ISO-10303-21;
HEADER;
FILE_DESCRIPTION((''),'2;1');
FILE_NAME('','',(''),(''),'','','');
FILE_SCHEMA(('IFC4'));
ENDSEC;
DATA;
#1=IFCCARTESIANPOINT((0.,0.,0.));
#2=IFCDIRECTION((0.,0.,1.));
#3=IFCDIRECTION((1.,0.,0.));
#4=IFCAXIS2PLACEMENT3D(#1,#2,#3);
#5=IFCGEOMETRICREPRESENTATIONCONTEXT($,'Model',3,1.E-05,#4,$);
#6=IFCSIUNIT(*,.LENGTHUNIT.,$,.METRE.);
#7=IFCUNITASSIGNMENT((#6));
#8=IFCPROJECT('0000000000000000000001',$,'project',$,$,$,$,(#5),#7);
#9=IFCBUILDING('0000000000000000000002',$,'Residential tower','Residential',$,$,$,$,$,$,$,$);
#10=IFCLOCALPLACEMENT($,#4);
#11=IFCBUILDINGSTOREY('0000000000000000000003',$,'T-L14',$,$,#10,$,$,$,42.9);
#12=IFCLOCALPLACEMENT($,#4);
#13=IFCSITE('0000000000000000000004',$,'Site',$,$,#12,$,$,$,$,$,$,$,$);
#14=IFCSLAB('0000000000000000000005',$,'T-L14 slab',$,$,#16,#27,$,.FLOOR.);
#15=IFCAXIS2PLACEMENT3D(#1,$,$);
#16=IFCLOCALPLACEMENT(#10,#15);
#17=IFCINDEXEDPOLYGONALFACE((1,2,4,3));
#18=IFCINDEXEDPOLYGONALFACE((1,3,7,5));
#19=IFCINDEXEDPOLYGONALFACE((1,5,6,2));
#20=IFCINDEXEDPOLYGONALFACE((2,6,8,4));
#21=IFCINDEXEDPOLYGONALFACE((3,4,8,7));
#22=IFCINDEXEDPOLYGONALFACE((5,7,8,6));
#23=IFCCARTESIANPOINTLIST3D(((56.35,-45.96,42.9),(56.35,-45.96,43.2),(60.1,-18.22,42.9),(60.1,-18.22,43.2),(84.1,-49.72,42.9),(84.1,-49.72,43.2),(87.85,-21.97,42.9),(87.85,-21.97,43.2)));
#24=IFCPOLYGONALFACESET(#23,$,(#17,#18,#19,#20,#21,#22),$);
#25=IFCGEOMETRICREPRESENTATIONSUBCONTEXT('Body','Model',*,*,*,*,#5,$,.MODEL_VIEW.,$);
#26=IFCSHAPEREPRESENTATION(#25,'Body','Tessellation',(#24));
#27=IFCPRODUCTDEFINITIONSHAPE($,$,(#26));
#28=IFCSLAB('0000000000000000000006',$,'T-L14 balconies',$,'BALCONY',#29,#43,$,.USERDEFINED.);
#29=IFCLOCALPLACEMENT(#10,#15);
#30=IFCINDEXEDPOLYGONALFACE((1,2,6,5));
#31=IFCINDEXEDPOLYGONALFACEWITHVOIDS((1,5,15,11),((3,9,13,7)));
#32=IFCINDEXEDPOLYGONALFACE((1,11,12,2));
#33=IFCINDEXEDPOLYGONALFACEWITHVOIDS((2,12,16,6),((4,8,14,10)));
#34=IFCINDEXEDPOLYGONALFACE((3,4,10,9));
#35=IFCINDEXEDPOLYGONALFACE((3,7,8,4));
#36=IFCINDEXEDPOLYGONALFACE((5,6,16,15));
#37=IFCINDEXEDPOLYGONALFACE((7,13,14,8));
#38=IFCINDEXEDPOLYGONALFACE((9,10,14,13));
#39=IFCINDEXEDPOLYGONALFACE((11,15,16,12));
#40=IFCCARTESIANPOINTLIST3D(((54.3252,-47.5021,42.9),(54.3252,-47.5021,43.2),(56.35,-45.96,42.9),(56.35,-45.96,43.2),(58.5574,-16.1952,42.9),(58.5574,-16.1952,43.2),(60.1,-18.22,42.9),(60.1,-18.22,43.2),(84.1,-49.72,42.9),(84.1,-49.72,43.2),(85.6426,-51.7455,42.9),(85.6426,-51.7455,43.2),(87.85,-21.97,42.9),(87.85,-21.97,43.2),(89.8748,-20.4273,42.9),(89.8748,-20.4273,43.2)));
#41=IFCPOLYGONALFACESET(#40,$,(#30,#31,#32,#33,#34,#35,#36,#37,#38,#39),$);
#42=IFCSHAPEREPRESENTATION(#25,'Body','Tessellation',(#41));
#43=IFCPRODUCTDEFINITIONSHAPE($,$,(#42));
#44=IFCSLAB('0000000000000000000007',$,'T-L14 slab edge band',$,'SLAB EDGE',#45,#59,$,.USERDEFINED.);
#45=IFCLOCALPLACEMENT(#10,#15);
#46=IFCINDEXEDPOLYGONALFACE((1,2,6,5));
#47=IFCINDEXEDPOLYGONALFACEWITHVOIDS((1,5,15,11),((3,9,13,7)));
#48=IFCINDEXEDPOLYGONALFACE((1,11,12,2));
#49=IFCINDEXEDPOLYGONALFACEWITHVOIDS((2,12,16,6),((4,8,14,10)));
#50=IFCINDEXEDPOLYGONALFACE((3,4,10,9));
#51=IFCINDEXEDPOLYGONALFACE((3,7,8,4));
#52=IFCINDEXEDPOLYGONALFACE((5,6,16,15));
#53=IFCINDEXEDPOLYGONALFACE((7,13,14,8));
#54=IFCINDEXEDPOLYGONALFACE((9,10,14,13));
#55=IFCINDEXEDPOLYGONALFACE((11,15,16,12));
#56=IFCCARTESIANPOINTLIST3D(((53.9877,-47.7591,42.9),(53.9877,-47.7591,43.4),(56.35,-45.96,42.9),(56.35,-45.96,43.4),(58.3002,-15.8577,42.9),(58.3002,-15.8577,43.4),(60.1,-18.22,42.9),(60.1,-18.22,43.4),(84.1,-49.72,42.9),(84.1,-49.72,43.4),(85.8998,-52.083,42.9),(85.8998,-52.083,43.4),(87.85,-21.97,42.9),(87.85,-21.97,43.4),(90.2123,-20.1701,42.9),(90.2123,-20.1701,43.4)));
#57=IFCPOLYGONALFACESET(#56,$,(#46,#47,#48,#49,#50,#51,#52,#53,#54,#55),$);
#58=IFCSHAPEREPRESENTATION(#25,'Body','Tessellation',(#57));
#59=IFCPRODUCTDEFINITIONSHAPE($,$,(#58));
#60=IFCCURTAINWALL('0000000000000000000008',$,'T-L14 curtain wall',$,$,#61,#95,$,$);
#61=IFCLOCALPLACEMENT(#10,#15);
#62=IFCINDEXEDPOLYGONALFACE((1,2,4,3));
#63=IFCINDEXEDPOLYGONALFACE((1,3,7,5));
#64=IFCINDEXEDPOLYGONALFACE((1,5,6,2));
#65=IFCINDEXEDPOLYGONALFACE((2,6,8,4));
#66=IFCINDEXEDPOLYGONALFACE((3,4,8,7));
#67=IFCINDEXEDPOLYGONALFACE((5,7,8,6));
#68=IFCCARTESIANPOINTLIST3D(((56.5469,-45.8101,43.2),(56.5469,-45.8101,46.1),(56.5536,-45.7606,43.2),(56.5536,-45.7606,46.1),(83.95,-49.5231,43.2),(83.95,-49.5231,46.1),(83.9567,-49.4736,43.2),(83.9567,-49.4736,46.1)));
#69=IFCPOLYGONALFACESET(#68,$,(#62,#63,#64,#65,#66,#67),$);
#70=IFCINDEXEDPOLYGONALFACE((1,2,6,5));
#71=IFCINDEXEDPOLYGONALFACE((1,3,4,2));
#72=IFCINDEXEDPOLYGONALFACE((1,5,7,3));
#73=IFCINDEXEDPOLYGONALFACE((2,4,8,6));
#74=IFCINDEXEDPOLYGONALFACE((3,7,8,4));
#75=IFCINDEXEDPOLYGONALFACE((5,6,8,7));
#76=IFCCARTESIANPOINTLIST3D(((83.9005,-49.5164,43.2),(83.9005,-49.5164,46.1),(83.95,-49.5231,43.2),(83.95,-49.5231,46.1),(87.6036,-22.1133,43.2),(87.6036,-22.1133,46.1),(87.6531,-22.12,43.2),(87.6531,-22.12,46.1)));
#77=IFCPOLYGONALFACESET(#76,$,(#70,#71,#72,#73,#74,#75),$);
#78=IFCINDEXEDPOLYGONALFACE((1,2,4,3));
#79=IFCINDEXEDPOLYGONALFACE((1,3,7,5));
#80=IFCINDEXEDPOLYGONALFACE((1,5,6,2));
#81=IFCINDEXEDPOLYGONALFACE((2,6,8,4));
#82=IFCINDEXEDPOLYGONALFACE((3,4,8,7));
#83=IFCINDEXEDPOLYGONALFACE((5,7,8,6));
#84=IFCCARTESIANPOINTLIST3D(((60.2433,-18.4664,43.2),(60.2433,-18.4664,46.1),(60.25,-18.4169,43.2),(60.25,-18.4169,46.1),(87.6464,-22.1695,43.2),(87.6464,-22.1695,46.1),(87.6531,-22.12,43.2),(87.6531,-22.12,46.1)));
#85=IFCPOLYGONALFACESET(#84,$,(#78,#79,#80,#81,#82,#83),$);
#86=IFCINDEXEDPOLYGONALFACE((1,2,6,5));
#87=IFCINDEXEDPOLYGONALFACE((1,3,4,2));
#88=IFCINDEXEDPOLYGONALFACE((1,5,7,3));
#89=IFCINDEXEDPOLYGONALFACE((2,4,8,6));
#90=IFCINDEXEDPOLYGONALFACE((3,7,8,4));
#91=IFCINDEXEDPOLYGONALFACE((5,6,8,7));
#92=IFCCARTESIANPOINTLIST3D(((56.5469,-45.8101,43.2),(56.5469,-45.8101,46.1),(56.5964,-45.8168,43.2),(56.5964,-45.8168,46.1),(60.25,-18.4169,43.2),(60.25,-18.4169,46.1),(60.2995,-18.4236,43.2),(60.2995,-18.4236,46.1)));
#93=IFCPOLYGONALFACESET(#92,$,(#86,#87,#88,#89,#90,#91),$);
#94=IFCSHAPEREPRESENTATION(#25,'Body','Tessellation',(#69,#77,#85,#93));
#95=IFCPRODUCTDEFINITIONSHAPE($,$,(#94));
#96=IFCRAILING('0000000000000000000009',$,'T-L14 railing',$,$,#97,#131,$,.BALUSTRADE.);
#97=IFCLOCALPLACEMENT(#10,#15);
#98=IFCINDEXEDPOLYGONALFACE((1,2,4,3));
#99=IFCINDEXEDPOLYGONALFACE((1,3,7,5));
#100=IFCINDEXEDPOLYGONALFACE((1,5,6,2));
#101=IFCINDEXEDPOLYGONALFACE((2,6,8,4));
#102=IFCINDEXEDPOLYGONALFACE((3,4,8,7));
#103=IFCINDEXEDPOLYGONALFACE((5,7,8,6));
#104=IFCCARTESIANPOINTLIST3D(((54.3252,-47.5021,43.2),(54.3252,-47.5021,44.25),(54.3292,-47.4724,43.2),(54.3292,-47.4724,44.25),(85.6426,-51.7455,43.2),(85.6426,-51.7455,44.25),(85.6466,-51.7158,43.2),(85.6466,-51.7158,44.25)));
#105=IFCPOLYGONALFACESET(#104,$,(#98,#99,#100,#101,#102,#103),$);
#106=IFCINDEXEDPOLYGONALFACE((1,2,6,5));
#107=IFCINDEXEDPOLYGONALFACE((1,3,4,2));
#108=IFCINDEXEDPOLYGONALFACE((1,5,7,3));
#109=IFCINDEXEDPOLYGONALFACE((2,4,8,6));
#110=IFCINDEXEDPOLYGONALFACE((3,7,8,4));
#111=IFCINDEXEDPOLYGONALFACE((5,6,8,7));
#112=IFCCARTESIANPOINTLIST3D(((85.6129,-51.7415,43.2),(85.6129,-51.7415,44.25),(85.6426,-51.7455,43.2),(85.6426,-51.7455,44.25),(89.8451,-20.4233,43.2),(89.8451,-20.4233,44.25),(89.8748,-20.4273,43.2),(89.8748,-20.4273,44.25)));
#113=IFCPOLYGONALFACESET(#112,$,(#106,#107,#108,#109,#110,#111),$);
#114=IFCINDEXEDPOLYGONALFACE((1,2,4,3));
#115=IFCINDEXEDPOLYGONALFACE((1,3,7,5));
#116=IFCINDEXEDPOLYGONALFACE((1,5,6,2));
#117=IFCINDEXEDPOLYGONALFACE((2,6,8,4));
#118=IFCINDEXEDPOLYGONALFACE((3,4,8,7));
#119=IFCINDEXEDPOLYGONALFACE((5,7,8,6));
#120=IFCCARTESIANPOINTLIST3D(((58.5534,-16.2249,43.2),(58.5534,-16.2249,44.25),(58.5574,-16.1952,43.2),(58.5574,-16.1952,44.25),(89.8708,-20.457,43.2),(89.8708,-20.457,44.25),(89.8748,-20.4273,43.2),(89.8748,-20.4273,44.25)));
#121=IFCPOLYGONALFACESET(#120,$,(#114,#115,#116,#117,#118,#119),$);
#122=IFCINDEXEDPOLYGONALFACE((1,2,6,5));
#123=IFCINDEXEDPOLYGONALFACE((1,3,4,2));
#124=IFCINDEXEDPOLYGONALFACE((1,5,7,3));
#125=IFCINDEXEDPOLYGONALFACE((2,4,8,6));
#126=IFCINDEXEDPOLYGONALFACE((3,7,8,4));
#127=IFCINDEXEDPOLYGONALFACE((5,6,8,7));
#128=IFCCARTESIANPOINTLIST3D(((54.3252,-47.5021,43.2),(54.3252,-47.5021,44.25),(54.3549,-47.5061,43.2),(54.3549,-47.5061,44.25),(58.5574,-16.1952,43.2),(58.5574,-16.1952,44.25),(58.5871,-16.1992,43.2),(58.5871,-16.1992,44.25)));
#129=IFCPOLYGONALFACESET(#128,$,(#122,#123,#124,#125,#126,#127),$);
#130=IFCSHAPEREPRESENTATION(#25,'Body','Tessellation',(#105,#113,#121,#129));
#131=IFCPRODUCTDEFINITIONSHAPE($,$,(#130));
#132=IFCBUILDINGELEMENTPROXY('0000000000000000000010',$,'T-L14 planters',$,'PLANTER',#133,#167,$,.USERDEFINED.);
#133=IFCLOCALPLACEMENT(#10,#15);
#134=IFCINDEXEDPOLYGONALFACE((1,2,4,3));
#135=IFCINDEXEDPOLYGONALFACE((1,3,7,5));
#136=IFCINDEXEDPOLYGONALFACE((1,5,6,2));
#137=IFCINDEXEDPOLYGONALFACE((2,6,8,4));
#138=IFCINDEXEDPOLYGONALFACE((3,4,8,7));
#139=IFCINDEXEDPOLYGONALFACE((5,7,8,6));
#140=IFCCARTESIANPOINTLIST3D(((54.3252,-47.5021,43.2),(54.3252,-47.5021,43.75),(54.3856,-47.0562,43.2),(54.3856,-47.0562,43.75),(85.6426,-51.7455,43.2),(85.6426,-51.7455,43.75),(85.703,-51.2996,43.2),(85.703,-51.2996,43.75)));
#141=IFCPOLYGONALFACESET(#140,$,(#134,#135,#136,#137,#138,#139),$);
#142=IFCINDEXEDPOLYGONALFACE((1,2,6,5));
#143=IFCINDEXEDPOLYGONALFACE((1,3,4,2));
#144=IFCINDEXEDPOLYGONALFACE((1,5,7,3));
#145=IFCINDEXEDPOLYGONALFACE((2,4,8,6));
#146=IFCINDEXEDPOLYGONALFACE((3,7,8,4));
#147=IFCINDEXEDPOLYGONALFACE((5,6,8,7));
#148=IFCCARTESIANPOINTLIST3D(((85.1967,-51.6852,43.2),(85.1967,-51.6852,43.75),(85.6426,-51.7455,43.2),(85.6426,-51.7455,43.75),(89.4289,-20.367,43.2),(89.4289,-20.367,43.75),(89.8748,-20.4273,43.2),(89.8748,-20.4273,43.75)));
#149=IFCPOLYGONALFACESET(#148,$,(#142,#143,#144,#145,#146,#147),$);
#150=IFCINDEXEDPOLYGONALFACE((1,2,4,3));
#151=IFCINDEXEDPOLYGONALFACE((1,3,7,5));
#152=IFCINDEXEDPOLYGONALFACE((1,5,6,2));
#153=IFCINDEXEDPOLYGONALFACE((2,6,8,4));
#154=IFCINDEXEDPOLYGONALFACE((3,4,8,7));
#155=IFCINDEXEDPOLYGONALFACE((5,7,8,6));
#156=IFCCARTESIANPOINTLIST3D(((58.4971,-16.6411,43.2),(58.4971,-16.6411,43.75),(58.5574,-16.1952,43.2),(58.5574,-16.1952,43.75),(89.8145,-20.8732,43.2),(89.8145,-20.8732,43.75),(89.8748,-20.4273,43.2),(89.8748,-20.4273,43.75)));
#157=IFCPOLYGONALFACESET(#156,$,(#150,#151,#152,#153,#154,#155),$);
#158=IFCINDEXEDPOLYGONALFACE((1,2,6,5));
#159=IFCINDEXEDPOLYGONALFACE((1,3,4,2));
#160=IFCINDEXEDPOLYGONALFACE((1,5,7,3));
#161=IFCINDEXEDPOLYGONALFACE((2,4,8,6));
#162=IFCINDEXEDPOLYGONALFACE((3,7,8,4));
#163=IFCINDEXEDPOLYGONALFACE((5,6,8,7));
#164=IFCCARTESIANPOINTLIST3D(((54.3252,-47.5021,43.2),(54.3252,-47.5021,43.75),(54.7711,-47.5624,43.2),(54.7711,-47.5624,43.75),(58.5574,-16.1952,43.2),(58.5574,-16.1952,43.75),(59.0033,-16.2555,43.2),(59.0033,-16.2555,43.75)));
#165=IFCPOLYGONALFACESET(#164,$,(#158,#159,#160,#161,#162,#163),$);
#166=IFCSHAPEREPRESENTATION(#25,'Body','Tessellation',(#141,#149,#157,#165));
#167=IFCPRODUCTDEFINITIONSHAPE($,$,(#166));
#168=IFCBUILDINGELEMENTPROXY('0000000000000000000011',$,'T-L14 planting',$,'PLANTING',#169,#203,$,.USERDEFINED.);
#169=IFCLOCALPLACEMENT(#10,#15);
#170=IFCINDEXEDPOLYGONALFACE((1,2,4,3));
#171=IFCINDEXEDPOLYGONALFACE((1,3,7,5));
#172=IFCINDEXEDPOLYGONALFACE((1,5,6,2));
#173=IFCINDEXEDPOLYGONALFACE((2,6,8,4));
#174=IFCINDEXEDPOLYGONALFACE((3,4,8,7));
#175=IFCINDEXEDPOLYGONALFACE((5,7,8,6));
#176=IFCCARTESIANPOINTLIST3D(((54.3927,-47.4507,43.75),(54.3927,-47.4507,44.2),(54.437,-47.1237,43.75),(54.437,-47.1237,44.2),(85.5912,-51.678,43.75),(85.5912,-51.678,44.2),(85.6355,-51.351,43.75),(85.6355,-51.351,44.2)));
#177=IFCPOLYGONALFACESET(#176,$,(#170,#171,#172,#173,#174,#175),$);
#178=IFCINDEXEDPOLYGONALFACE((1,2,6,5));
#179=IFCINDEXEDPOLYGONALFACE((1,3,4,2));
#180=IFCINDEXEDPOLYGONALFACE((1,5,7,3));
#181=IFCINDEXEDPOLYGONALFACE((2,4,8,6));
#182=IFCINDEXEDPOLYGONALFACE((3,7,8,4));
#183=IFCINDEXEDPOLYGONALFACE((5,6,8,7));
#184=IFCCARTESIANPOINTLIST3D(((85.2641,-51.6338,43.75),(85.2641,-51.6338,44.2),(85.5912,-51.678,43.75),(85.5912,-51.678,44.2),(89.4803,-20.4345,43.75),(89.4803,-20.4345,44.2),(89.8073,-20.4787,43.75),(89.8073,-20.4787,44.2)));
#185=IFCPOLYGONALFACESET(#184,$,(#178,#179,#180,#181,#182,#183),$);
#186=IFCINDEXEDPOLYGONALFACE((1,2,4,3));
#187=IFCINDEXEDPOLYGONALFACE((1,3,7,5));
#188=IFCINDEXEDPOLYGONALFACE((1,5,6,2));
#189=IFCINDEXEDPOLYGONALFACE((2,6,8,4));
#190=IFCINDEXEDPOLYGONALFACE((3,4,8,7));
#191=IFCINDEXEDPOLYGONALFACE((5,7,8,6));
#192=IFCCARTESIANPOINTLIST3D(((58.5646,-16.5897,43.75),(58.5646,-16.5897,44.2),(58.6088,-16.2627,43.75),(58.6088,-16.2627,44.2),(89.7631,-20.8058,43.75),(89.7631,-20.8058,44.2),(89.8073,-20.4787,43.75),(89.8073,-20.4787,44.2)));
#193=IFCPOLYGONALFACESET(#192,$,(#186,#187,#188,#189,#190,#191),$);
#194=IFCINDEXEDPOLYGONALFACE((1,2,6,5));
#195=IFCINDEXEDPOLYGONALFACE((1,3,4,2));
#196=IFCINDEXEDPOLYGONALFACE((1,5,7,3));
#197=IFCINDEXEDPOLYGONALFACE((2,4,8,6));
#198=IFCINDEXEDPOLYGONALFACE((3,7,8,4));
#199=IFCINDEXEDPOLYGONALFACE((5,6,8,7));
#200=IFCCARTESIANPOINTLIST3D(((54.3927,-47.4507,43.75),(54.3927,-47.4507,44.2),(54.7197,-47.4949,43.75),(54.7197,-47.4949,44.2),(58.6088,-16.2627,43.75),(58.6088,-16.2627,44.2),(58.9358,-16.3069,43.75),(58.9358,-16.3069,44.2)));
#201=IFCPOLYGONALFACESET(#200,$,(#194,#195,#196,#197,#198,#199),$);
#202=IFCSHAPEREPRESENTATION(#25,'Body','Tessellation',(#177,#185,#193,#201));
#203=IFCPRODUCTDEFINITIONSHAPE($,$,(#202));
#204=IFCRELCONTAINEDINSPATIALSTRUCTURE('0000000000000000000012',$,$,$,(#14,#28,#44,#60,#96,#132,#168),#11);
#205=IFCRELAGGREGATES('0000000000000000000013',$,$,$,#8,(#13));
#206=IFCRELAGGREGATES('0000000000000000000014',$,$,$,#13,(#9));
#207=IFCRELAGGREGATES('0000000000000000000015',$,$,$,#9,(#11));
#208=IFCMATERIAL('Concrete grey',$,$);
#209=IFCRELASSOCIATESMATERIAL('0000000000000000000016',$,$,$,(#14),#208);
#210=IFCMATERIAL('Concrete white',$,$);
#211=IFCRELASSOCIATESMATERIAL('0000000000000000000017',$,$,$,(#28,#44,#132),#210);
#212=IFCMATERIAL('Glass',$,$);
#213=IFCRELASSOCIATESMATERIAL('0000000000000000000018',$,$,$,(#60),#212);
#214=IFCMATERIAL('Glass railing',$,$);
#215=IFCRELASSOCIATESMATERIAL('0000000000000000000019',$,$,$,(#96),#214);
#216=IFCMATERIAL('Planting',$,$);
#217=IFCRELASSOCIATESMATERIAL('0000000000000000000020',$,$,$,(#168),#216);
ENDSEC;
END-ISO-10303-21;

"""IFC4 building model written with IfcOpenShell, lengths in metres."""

from ifc_helpers import new_model, si_unit, frame, origin_with_axes, place, context, subcontext, project, spatial, polyline, outline, extrude, material, element, save


model = new_model("IFC4")

# Units and contexts
model_context = context("Model", 3, precision=1e-05, world=origin_with_axes())
body_context = subcontext(model_context, "Body", "Model", "MODEL_VIEW")
ifc_project = project(units=[si_unit("LENGTHUNIT", "METRE")], contexts=[model_context])

# Site, building, storey
site_placement = place(None, origin_with_axes())
site = spatial("IfcSite", under=ifc_project, at=site_placement, Name="Site")
building = spatial("IfcBuilding", under=site, Name="Residential tower", Description="Residential")
storey_placement = place(None, origin_with_axes())
storey = spatial("IfcBuildingStorey", under=building, at=storey_placement, Name="T-L14", Elevation=42.9)

# Slabs
ifc_material_1 = material(Name="Concrete grey")
slab_1_placement = place(storey_placement, origin_with_axes())
element("IfcSlab", 1, at=slab_1_placement, inside=storey, material=ifc_material_1, Name="T-L14 slab", PredefinedType="FLOOR", context=body_context, shape_type="SweptSolid", body=[
    extrude(outline(polyline([(56.35, -45.96), (84.1, -49.72), (87.85, -21.97), (60.1, -18.22), (56.35, -45.96)])), frame((0.0, 0.0, 42.9), z_axis=(0.0, 0.0, 1.0), x_axis=(1.0, 0.0, 0.0)), (0.0, 0.0, 1.0), 0.3),
])
ifc_material_2 = material(Name="Concrete white")
slab_2_placement = place(storey_placement, origin_with_axes())
element("IfcSlab", 2, at=slab_2_placement, inside=storey, material=ifc_material_2, Name="T-L14 balconies", ObjectType="BALCONY", PredefinedType="USERDEFINED", context=body_context, shape_type="SweptSolid", body=[
    extrude(outline(polyline([(54.3252, -47.5021), (85.6426, -51.7455), (89.8748, -20.4273), (58.5574, -16.1952), (54.3252, -47.5021)]), holes=[polyline([(56.35, -45.96), (84.1, -49.72), (87.85, -21.97), (60.1, -18.22), (56.35, -45.96)])]), frame((0.0, 0.0, 42.9), z_axis=(0.0, 0.0, 1.0), x_axis=(1.0, 0.0, 0.0)), (0.0, 0.0, 1.0), 0.3),
])
slab_3_placement = place(storey_placement, origin_with_axes())
element("IfcSlab", 3, at=slab_3_placement, inside=storey, material=ifc_material_2, Name="T-L14 slab edge band", ObjectType="SLAB EDGE", PredefinedType="USERDEFINED", context=body_context, shape_type="SweptSolid", body=[
    extrude(outline(polyline([(53.9877, -47.7591), (85.8998, -52.083), (90.2123, -20.1701), (58.3002, -15.8577), (53.9877, -47.7591)]), holes=[polyline([(56.35, -45.96), (84.1, -49.72), (87.85, -21.97), (60.1, -18.22), (56.35, -45.96)])]), frame((0.0, 0.0, 42.9), z_axis=(0.0, 0.0, 1.0), x_axis=(1.0, 0.0, 0.0)), (0.0, 0.0, 1.0), 0.5),
])

# Curtain wall
ifc_material_3 = material(Name="Glass")
curtain_wall_placement = place(storey_placement, origin_with_axes())
element("IfcCurtainWall", 4, at=curtain_wall_placement, inside=storey, material=ifc_material_3, Name="T-L14 curtain wall", context=body_context, shape_type="SweptSolid", body=[
    extrude(outline(polyline([(56.5469, -45.8101), (83.95, -49.5231), (83.9567, -49.4736), (56.5536, -45.7606), (56.5469, -45.8101)])), frame((0.0, 0.0, 43.2), z_axis=(0.0, 0.0, 1.0), x_axis=(1.0, 0.0, 0.0)), (0.0, 0.0, 1.0), 2.9),
    extrude(outline(polyline([(83.95, -49.5231), (87.6531, -22.12), (87.6036, -22.1133), (83.9005, -49.5164), (83.95, -49.5231)])), frame((0.0, 0.0, 43.2), z_axis=(0.0, 0.0, 1.0), x_axis=(1.0, 0.0, 0.0)), (0.0, 0.0, 1.0), 2.9),
    extrude(outline(polyline([(87.6531, -22.12), (60.25, -18.4169), (60.2433, -18.4664), (87.6464, -22.1695), (87.6531, -22.12)])), frame((0.0, 0.0, 43.2), z_axis=(0.0, 0.0, 1.0), x_axis=(1.0, 0.0, 0.0)), (0.0, 0.0, 1.0), 2.9),
    extrude(outline(polyline([(60.25, -18.4169), (56.5469, -45.8101), (56.5964, -45.8168), (60.2995, -18.4236), (60.25, -18.4169)])), frame((0.0, 0.0, 43.2), z_axis=(0.0, 0.0, 1.0), x_axis=(1.0, 0.0, 0.0)), (0.0, 0.0, 1.0), 2.9),
])

# Railing
ifc_material_4 = material(Name="Glass railing")
railing_placement = place(storey_placement, origin_with_axes())
element("IfcRailing", 5, at=railing_placement, inside=storey, material=ifc_material_4, Name="T-L14 railing", PredefinedType="BALUSTRADE", context=body_context, shape_type="SweptSolid", body=[
    extrude(outline(polyline([(54.3252, -47.5021), (85.6426, -51.7455), (85.6466, -51.7158), (54.3292, -47.4724), (54.3252, -47.5021)])), frame((0.0, 0.0, 43.2), z_axis=(0.0, 0.0, 1.0), x_axis=(1.0, 0.0, 0.0)), (0.0, 0.0, 1.0), 1.05),
    extrude(outline(polyline([(85.6426, -51.7455), (89.8748, -20.4273), (89.8451, -20.4233), (85.6129, -51.7415), (85.6426, -51.7455)])), frame((0.0, 0.0, 43.2), z_axis=(0.0, 0.0, 1.0), x_axis=(1.0, 0.0, 0.0)), (0.0, 0.0, 1.0), 1.05),
    extrude(outline(polyline([(89.8748, -20.4273), (58.5574, -16.1952), (58.5534, -16.2249), (89.8708, -20.457), (89.8748, -20.4273)])), frame((0.0, 0.0, 43.2), z_axis=(0.0, 0.0, 1.0), x_axis=(1.0, 0.0, 0.0)), (0.0, 0.0, 1.0), 1.05),
    extrude(outline(polyline([(58.5574, -16.1952), (54.3252, -47.5021), (54.3549, -47.5061), (58.5871, -16.1992), (58.5574, -16.1952)])), frame((0.0, 0.0, 43.2), z_axis=(0.0, 0.0, 1.0), x_axis=(1.0, 0.0, 0.0)), (0.0, 0.0, 1.0), 1.05),
])

# Building element proxies
proxy_1_placement = place(storey_placement, origin_with_axes())
element("IfcBuildingElementProxy", 6, at=proxy_1_placement, inside=storey, material=ifc_material_2, Name="T-L14 planters", ObjectType="PLANTER", PredefinedType="USERDEFINED", context=body_context, shape_type="SweptSolid", body=[
    extrude(outline(polyline([(54.3252, -47.5021), (85.6426, -51.7455), (85.703, -51.2996), (54.3856, -47.0562), (54.3252, -47.5021)])), frame((0.0, 0.0, 43.2), z_axis=(0.0, 0.0, 1.0), x_axis=(1.0, 0.0, 0.0)), (0.0, 0.0, 1.0), 0.55),
    extrude(outline(polyline([(85.6426, -51.7455), (89.8748, -20.4273), (89.4289, -20.367), (85.1967, -51.6852), (85.6426, -51.7455)])), frame((0.0, 0.0, 43.2), z_axis=(0.0, 0.0, 1.0), x_axis=(1.0, 0.0, 0.0)), (0.0, 0.0, 1.0), 0.55),
    extrude(outline(polyline([(89.8748, -20.4273), (58.5574, -16.1952), (58.4971, -16.6411), (89.8145, -20.8732), (89.8748, -20.4273)])), frame((0.0, 0.0, 43.2), z_axis=(0.0, 0.0, 1.0), x_axis=(1.0, 0.0, 0.0)), (0.0, 0.0, 1.0), 0.55),
    extrude(outline(polyline([(58.5574, -16.1952), (54.3252, -47.5021), (54.7711, -47.5624), (59.0033, -16.2555), (58.5574, -16.1952)])), frame((0.0, 0.0, 43.2), z_axis=(0.0, 0.0, 1.0), x_axis=(1.0, 0.0, 0.0)), (0.0, 0.0, 1.0), 0.55),
])
ifc_material_5 = material(Name="Planting")
proxy_2_placement = place(storey_placement, origin_with_axes())
element("IfcBuildingElementProxy", 7, at=proxy_2_placement, inside=storey, material=ifc_material_5, Name="T-L14 planting", ObjectType="PLANTING", PredefinedType="USERDEFINED", context=body_context, shape_type="SweptSolid", body=[
    extrude(outline(polyline([(54.3927, -47.4507), (85.5912, -51.678), (85.6355, -51.351), (54.437, -47.1237), (54.3927, -47.4507)])), frame((0.0, 0.0, 43.75), z_axis=(0.0, 0.0, 1.0), x_axis=(1.0, 0.0, 0.0)), (0.0, 0.0, 1.0), 0.45),
    extrude(outline(polyline([(85.5912, -51.678), (89.8073, -20.4787), (89.4803, -20.4345), (85.2641, -51.6338), (85.5912, -51.678)])), frame((0.0, 0.0, 43.75), z_axis=(0.0, 0.0, 1.0), x_axis=(1.0, 0.0, 0.0)), (0.0, 0.0, 1.0), 0.45),
    extrude(outline(polyline([(89.8073, -20.4787), (58.6088, -16.2627), (58.5646, -16.5897), (89.7631, -20.8058), (89.8073, -20.4787)])), frame((0.0, 0.0, 43.75), z_axis=(0.0, 0.0, 1.0), x_axis=(1.0, 0.0, 0.0)), (0.0, 0.0, 1.0), 0.45),
    extrude(outline(polyline([(58.6088, -16.2627), (54.3927, -47.4507), (54.7197, -47.4949), (58.9358, -16.3069), (58.6088, -16.2627)])), frame((0.0, 0.0, 43.75), z_axis=(0.0, 0.0, 1.0), x_axis=(1.0, 0.0, 0.0)), (0.0, 0.0, 1.0), 0.45),
])

save(model, "model.ifc")
